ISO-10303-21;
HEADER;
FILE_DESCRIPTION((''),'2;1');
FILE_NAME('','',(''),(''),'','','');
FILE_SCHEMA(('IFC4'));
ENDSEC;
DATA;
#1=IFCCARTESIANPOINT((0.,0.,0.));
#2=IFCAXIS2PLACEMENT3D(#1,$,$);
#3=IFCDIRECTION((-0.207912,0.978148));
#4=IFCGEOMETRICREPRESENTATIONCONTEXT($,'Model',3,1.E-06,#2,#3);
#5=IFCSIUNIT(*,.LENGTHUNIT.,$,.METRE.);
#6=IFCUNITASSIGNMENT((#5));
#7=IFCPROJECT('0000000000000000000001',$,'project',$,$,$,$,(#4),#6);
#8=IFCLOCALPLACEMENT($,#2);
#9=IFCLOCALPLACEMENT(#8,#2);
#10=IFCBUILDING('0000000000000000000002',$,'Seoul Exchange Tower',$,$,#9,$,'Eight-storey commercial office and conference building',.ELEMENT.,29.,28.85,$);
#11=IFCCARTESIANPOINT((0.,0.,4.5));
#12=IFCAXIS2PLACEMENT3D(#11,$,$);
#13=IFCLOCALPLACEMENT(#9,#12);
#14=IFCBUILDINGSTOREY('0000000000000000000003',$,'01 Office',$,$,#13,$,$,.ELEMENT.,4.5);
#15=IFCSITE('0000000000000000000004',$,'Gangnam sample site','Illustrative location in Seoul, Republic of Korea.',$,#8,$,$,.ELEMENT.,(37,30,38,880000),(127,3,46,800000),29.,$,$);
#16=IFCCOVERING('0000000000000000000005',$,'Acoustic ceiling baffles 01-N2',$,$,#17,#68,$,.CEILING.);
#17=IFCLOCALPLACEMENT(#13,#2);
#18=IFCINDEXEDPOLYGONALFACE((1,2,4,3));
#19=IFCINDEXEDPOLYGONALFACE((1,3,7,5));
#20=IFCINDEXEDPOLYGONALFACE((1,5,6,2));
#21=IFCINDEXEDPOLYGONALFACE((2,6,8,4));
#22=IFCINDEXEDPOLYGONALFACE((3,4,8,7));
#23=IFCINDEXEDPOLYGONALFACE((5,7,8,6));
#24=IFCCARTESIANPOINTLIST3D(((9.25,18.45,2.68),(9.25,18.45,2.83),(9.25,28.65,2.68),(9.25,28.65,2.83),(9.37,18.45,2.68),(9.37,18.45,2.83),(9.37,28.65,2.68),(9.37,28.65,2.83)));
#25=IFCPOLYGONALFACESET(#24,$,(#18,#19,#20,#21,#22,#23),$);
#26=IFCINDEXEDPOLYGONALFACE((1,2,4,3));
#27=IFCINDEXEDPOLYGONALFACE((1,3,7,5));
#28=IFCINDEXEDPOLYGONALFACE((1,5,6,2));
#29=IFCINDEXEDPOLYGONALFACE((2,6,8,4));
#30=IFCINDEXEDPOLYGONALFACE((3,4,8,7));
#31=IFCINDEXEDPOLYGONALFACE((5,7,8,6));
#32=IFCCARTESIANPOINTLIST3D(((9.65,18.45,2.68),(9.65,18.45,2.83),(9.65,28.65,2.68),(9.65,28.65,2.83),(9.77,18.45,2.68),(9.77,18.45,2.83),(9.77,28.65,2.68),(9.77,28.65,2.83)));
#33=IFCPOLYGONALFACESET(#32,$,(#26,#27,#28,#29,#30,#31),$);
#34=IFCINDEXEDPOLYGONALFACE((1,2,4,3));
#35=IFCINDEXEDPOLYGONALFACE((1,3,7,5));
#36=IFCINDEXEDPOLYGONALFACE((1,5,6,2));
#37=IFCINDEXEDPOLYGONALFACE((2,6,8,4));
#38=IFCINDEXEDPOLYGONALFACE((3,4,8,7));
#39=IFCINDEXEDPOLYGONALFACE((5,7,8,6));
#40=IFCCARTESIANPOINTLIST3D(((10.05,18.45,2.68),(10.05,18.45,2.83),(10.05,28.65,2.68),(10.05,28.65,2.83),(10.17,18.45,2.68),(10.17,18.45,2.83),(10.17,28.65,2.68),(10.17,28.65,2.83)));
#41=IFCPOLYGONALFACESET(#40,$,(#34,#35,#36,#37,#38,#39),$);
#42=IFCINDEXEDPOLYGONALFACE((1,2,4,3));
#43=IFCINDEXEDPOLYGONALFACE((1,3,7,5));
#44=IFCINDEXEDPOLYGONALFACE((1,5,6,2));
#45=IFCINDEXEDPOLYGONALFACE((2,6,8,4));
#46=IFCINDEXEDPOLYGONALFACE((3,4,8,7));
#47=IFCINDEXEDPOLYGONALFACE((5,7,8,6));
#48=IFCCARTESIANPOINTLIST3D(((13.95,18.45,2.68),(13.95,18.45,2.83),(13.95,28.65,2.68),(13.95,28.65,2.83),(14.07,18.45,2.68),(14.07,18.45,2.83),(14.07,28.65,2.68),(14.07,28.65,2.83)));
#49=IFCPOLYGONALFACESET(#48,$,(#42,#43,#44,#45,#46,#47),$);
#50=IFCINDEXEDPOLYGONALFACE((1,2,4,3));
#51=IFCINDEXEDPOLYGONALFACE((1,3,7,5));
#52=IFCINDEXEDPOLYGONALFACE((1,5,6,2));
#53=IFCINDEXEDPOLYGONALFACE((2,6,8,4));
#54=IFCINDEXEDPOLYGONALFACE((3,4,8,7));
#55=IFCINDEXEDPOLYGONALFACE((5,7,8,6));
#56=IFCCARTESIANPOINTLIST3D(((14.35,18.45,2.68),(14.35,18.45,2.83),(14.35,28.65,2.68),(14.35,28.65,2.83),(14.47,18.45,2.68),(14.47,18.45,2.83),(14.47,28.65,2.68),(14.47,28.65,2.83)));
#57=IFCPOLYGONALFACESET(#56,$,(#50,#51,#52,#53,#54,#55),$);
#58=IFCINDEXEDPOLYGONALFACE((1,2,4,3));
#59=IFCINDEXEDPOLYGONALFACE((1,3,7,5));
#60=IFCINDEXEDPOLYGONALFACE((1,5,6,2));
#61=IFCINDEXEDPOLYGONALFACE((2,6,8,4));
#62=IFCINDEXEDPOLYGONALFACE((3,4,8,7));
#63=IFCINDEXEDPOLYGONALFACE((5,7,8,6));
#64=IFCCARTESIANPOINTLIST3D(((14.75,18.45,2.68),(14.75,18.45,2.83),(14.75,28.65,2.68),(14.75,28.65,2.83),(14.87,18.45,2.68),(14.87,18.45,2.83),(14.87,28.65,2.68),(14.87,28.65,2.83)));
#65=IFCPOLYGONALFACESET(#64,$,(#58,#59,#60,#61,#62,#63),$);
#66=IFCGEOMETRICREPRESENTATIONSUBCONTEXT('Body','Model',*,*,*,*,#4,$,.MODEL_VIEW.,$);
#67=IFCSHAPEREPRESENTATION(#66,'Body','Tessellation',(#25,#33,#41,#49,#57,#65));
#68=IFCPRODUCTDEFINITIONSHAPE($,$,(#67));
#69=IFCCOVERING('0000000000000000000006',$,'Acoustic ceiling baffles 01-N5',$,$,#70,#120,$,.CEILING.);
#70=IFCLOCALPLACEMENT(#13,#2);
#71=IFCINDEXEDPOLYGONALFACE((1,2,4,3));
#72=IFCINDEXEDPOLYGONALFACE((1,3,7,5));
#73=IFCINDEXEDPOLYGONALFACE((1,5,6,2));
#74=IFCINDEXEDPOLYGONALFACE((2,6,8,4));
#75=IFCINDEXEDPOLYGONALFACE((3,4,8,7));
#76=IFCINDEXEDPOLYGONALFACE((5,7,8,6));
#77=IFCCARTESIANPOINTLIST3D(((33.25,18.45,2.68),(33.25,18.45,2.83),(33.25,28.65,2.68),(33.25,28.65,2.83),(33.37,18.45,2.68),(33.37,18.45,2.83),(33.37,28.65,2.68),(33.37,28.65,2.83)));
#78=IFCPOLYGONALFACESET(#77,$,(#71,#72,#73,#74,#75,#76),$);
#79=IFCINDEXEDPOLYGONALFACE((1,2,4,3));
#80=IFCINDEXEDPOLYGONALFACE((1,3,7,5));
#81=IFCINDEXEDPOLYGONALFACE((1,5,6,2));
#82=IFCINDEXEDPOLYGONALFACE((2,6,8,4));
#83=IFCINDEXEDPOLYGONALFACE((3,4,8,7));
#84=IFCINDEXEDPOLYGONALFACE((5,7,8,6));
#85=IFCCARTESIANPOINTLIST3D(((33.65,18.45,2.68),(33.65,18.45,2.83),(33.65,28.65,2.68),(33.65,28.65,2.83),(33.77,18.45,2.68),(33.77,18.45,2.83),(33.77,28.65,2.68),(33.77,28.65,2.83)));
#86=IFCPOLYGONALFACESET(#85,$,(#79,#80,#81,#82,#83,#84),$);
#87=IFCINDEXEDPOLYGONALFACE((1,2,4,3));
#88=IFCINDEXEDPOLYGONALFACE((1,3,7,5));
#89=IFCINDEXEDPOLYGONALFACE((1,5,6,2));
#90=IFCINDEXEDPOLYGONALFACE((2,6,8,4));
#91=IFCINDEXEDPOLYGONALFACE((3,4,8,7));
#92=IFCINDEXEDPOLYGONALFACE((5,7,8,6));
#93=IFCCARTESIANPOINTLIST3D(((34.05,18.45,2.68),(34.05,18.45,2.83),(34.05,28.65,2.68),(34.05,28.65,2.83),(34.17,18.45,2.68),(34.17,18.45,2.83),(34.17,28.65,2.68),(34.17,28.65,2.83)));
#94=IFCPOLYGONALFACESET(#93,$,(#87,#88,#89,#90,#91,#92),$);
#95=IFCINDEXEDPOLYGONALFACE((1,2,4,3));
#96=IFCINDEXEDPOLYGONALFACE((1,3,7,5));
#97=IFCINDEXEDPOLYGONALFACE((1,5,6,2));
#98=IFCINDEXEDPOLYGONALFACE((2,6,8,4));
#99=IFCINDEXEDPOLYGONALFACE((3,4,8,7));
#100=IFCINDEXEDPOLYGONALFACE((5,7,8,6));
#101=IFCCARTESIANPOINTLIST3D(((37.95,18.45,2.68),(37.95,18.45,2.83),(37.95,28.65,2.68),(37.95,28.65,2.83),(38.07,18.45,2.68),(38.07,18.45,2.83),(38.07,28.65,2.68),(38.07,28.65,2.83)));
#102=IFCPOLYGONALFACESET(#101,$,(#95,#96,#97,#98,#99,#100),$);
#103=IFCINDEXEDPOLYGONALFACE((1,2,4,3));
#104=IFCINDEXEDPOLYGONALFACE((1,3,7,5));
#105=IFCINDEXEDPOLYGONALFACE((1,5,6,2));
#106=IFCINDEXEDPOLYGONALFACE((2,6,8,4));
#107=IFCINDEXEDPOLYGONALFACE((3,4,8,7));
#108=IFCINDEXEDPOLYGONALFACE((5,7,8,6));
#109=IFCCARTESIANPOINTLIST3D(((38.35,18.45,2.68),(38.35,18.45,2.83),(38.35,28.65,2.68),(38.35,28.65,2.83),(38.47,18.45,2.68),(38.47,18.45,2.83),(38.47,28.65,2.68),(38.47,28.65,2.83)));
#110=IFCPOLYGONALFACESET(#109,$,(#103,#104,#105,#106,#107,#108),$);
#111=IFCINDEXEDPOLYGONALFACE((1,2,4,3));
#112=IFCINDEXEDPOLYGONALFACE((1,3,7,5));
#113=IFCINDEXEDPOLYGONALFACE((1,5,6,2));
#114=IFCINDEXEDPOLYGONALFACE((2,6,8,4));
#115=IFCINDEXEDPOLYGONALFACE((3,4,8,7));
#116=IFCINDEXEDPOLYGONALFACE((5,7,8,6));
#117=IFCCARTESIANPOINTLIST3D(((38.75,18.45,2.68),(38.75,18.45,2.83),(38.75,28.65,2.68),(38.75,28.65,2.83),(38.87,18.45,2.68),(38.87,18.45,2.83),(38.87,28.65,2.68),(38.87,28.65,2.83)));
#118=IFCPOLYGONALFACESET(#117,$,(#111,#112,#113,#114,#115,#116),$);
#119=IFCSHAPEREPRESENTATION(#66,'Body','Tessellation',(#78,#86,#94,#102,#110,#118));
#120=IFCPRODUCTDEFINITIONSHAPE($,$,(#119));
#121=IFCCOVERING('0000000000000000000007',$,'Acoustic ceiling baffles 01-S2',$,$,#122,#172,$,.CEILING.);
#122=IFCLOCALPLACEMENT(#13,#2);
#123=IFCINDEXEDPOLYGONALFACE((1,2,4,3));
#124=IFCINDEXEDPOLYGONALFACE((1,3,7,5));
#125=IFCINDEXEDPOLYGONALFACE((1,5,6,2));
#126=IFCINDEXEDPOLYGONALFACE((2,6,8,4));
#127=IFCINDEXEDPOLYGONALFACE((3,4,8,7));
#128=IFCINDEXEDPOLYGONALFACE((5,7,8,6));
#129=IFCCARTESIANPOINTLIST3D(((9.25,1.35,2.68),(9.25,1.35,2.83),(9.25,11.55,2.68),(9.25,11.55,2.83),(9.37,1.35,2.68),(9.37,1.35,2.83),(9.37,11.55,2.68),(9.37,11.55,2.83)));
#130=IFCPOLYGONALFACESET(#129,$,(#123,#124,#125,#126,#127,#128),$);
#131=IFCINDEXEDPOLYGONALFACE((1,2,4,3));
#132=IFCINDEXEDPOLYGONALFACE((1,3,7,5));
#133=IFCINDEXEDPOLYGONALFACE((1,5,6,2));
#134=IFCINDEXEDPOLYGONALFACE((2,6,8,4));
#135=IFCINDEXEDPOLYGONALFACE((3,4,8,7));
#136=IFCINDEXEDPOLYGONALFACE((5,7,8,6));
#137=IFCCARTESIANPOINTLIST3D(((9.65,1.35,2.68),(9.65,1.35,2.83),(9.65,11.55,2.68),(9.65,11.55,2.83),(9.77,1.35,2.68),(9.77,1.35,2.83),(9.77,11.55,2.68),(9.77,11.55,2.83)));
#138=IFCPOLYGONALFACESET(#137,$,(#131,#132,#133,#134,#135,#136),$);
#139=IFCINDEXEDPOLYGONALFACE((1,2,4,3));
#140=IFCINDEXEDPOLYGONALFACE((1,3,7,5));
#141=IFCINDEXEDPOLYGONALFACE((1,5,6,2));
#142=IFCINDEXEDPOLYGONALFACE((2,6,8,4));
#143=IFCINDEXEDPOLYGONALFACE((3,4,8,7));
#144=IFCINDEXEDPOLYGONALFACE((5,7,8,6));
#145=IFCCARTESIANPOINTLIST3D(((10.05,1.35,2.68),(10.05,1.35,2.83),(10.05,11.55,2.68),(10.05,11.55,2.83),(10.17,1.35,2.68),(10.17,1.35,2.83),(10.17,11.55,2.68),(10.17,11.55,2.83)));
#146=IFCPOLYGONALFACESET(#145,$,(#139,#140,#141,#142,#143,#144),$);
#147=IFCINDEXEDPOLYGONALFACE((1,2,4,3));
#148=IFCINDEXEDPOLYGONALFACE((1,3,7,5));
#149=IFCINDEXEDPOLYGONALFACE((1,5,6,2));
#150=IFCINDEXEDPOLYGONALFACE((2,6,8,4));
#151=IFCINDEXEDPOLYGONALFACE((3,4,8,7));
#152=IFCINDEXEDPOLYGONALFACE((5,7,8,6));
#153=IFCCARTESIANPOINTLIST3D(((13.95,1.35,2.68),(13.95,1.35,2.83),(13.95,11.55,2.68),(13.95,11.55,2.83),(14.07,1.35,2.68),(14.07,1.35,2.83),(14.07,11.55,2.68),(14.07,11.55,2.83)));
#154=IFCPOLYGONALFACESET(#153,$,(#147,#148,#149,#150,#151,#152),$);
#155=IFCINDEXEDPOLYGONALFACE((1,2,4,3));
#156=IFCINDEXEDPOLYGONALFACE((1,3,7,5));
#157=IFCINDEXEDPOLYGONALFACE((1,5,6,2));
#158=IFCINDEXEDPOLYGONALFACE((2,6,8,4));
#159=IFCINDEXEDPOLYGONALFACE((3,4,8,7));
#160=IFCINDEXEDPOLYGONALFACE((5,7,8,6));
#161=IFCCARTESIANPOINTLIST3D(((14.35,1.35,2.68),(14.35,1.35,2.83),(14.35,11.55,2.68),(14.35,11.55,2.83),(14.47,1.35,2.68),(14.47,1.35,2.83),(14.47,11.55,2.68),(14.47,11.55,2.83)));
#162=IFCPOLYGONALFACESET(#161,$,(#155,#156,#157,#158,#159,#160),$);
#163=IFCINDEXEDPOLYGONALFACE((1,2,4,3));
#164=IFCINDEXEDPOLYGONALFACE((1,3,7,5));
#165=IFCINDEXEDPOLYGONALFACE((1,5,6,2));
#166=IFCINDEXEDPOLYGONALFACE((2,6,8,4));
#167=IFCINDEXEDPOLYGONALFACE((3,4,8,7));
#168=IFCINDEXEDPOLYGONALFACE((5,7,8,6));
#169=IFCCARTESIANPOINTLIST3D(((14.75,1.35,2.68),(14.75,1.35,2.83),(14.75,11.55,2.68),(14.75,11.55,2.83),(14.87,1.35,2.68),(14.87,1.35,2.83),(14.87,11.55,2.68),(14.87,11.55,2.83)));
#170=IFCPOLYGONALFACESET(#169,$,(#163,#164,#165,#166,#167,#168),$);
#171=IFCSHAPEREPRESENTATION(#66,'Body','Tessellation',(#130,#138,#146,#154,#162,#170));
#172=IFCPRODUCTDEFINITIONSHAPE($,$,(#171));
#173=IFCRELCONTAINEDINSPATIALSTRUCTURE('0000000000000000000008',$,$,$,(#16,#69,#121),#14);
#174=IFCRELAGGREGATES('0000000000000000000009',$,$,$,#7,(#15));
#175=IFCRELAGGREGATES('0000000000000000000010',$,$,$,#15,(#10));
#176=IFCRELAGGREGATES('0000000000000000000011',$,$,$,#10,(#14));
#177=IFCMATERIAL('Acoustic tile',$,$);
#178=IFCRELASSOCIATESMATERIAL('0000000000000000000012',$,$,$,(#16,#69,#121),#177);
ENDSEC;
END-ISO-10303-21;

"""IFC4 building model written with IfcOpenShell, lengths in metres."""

from ifc_helpers import new_model, si_unit, direction, frame, frame_2d, origin, place, context, subcontext, project, spatial, rectangle, extrude, material, element, save


model = new_model("IFC4")

# Units and contexts
model_context = context("Model", 3, precision=1e-06, world=origin(), true_north=direction((-0.207912, 0.978148)))
body_context = subcontext(model_context, "Body", "Model", "MODEL_VIEW")
ifc_project = project(units=[si_unit("LENGTHUNIT", "METRE")], contexts=[model_context])

# Site, building, storey
site_placement = place(None, origin())
site = spatial("IfcSite", under=ifc_project, at=site_placement, Name="Gangnam sample site", Description="Illustrative location in Seoul, Republic of Korea.", CompositionType="ELEMENT", RefLatitude=(37, 30, 38, 880000), RefLongitude=(127, 3, 46, 800000), RefElevation=29.0)
building_placement = place(site_placement, origin())
building = spatial("IfcBuilding", under=site, at=building_placement, Name="Seoul Exchange Tower", LongName="Eight-storey commercial office and conference building", CompositionType="ELEMENT", ElevationOfRefHeight=29.0, ElevationOfTerrain=28.85)
storey_placement = place(building_placement, frame((0.0, 0.0, 4.5)))
storey = spatial("IfcBuildingStorey", under=building, at=storey_placement, Name="01 Office", CompositionType="ELEMENT", Elevation=4.5)

# Shared definitions
placement_1 = place(storey_placement, origin())

# Coverings
ifc_material_1 = material(Name="Acoustic tile")
element("IfcCovering", 1, at=placement_1, inside=storey, material=ifc_material_1, Name="Acoustic ceiling baffles 01-N2", PredefinedType="CEILING", context=body_context, shape_type="SweptSolid", body=[
    extrude(rectangle(XDim=0.12, YDim=10.2, at=frame_2d((0.06, 5.1))), frame((9.25, 18.45, 2.68)), (0.0, 0.0, 1.0), 0.15),
    extrude(rectangle(XDim=0.12, YDim=10.2, at=frame_2d((0.06, 5.1))), frame((9.65, 18.45, 2.68)), (0.0, 0.0, 1.0), 0.15),
    extrude(rectangle(XDim=0.12, YDim=10.2, at=frame_2d((0.06, 5.1))), frame((10.05, 18.45, 2.68)), (0.0, 0.0, 1.0), 0.15),
    extrude(rectangle(XDim=0.12, YDim=10.2, at=frame_2d((0.06, 5.1))), frame((13.95, 18.45, 2.68)), (0.0, 0.0, 1.0), 0.15),
    extrude(rectangle(XDim=0.12, YDim=10.2, at=frame_2d((0.06, 5.1))), frame((14.35, 18.45, 2.68)), (0.0, 0.0, 1.0), 0.15),
    extrude(rectangle(XDim=0.12, YDim=10.2, at=frame_2d((0.06, 5.1))), frame((14.75, 18.45, 2.68)), (0.0, 0.0, 1.0), 0.15),
])
element("IfcCovering", 2, at=placement_1, inside=storey, material=ifc_material_1, Name="Acoustic ceiling baffles 01-N5", PredefinedType="CEILING", context=body_context, shape_type="SweptSolid", body=[
    extrude(rectangle(XDim=0.12, YDim=10.2, at=frame_2d((0.06, 5.1))), frame((33.25, 18.45, 2.68)), (0.0, 0.0, 1.0), 0.15),
    extrude(rectangle(XDim=0.12, YDim=10.2, at=frame_2d((0.06, 5.1))), frame((33.65, 18.45, 2.68)), (0.0, 0.0, 1.0), 0.15),
    extrude(rectangle(XDim=0.12, YDim=10.2, at=frame_2d((0.06, 5.1))), frame((34.05, 18.45, 2.68)), (0.0, 0.0, 1.0), 0.15),
    extrude(rectangle(XDim=0.12, YDim=10.2, at=frame_2d((0.06, 5.1))), frame((37.95, 18.45, 2.68)), (0.0, 0.0, 1.0), 0.15),
    extrude(rectangle(XDim=0.12, YDim=10.2, at=frame_2d((0.06, 5.1))), frame((38.35, 18.45, 2.68)), (0.0, 0.0, 1.0), 0.15),
    extrude(rectangle(XDim=0.12, YDim=10.2, at=frame_2d((0.06, 5.1))), frame((38.75, 18.45, 2.68)), (0.0, 0.0, 1.0), 0.15),
])
element("IfcCovering", 3, at=placement_1, inside=storey, material=ifc_material_1, Name="Acoustic ceiling baffles 01-S2", PredefinedType="CEILING", context=body_context, shape_type="SweptSolid", body=[
    extrude(rectangle(XDim=0.12, YDim=10.2, at=frame_2d((0.06, 5.1))), frame((9.25, 1.35, 2.68)), (0.0, 0.0, 1.0), 0.15),
    extrude(rectangle(XDim=0.12, YDim=10.2, at=frame_2d((0.06, 5.1))), frame((9.65, 1.35, 2.68)), (0.0, 0.0, 1.0), 0.15),
    extrude(rectangle(XDim=0.12, YDim=10.2, at=frame_2d((0.06, 5.1))), frame((10.05, 1.35, 2.68)), (0.0, 0.0, 1.0), 0.15),
    extrude(rectangle(XDim=0.12, YDim=10.2, at=frame_2d((0.06, 5.1))), frame((13.95, 1.35, 2.68)), (0.0, 0.0, 1.0), 0.15),
    extrude(rectangle(XDim=0.12, YDim=10.2, at=frame_2d((0.06, 5.1))), frame((14.35, 1.35, 2.68)), (0.0, 0.0, 1.0), 0.15),
    extrude(rectangle(XDim=0.12, YDim=10.2, at=frame_2d((0.06, 5.1))), frame((14.75, 1.35, 2.68)), (0.0, 0.0, 1.0), 0.15),
])

save(model, "model.ifc")
